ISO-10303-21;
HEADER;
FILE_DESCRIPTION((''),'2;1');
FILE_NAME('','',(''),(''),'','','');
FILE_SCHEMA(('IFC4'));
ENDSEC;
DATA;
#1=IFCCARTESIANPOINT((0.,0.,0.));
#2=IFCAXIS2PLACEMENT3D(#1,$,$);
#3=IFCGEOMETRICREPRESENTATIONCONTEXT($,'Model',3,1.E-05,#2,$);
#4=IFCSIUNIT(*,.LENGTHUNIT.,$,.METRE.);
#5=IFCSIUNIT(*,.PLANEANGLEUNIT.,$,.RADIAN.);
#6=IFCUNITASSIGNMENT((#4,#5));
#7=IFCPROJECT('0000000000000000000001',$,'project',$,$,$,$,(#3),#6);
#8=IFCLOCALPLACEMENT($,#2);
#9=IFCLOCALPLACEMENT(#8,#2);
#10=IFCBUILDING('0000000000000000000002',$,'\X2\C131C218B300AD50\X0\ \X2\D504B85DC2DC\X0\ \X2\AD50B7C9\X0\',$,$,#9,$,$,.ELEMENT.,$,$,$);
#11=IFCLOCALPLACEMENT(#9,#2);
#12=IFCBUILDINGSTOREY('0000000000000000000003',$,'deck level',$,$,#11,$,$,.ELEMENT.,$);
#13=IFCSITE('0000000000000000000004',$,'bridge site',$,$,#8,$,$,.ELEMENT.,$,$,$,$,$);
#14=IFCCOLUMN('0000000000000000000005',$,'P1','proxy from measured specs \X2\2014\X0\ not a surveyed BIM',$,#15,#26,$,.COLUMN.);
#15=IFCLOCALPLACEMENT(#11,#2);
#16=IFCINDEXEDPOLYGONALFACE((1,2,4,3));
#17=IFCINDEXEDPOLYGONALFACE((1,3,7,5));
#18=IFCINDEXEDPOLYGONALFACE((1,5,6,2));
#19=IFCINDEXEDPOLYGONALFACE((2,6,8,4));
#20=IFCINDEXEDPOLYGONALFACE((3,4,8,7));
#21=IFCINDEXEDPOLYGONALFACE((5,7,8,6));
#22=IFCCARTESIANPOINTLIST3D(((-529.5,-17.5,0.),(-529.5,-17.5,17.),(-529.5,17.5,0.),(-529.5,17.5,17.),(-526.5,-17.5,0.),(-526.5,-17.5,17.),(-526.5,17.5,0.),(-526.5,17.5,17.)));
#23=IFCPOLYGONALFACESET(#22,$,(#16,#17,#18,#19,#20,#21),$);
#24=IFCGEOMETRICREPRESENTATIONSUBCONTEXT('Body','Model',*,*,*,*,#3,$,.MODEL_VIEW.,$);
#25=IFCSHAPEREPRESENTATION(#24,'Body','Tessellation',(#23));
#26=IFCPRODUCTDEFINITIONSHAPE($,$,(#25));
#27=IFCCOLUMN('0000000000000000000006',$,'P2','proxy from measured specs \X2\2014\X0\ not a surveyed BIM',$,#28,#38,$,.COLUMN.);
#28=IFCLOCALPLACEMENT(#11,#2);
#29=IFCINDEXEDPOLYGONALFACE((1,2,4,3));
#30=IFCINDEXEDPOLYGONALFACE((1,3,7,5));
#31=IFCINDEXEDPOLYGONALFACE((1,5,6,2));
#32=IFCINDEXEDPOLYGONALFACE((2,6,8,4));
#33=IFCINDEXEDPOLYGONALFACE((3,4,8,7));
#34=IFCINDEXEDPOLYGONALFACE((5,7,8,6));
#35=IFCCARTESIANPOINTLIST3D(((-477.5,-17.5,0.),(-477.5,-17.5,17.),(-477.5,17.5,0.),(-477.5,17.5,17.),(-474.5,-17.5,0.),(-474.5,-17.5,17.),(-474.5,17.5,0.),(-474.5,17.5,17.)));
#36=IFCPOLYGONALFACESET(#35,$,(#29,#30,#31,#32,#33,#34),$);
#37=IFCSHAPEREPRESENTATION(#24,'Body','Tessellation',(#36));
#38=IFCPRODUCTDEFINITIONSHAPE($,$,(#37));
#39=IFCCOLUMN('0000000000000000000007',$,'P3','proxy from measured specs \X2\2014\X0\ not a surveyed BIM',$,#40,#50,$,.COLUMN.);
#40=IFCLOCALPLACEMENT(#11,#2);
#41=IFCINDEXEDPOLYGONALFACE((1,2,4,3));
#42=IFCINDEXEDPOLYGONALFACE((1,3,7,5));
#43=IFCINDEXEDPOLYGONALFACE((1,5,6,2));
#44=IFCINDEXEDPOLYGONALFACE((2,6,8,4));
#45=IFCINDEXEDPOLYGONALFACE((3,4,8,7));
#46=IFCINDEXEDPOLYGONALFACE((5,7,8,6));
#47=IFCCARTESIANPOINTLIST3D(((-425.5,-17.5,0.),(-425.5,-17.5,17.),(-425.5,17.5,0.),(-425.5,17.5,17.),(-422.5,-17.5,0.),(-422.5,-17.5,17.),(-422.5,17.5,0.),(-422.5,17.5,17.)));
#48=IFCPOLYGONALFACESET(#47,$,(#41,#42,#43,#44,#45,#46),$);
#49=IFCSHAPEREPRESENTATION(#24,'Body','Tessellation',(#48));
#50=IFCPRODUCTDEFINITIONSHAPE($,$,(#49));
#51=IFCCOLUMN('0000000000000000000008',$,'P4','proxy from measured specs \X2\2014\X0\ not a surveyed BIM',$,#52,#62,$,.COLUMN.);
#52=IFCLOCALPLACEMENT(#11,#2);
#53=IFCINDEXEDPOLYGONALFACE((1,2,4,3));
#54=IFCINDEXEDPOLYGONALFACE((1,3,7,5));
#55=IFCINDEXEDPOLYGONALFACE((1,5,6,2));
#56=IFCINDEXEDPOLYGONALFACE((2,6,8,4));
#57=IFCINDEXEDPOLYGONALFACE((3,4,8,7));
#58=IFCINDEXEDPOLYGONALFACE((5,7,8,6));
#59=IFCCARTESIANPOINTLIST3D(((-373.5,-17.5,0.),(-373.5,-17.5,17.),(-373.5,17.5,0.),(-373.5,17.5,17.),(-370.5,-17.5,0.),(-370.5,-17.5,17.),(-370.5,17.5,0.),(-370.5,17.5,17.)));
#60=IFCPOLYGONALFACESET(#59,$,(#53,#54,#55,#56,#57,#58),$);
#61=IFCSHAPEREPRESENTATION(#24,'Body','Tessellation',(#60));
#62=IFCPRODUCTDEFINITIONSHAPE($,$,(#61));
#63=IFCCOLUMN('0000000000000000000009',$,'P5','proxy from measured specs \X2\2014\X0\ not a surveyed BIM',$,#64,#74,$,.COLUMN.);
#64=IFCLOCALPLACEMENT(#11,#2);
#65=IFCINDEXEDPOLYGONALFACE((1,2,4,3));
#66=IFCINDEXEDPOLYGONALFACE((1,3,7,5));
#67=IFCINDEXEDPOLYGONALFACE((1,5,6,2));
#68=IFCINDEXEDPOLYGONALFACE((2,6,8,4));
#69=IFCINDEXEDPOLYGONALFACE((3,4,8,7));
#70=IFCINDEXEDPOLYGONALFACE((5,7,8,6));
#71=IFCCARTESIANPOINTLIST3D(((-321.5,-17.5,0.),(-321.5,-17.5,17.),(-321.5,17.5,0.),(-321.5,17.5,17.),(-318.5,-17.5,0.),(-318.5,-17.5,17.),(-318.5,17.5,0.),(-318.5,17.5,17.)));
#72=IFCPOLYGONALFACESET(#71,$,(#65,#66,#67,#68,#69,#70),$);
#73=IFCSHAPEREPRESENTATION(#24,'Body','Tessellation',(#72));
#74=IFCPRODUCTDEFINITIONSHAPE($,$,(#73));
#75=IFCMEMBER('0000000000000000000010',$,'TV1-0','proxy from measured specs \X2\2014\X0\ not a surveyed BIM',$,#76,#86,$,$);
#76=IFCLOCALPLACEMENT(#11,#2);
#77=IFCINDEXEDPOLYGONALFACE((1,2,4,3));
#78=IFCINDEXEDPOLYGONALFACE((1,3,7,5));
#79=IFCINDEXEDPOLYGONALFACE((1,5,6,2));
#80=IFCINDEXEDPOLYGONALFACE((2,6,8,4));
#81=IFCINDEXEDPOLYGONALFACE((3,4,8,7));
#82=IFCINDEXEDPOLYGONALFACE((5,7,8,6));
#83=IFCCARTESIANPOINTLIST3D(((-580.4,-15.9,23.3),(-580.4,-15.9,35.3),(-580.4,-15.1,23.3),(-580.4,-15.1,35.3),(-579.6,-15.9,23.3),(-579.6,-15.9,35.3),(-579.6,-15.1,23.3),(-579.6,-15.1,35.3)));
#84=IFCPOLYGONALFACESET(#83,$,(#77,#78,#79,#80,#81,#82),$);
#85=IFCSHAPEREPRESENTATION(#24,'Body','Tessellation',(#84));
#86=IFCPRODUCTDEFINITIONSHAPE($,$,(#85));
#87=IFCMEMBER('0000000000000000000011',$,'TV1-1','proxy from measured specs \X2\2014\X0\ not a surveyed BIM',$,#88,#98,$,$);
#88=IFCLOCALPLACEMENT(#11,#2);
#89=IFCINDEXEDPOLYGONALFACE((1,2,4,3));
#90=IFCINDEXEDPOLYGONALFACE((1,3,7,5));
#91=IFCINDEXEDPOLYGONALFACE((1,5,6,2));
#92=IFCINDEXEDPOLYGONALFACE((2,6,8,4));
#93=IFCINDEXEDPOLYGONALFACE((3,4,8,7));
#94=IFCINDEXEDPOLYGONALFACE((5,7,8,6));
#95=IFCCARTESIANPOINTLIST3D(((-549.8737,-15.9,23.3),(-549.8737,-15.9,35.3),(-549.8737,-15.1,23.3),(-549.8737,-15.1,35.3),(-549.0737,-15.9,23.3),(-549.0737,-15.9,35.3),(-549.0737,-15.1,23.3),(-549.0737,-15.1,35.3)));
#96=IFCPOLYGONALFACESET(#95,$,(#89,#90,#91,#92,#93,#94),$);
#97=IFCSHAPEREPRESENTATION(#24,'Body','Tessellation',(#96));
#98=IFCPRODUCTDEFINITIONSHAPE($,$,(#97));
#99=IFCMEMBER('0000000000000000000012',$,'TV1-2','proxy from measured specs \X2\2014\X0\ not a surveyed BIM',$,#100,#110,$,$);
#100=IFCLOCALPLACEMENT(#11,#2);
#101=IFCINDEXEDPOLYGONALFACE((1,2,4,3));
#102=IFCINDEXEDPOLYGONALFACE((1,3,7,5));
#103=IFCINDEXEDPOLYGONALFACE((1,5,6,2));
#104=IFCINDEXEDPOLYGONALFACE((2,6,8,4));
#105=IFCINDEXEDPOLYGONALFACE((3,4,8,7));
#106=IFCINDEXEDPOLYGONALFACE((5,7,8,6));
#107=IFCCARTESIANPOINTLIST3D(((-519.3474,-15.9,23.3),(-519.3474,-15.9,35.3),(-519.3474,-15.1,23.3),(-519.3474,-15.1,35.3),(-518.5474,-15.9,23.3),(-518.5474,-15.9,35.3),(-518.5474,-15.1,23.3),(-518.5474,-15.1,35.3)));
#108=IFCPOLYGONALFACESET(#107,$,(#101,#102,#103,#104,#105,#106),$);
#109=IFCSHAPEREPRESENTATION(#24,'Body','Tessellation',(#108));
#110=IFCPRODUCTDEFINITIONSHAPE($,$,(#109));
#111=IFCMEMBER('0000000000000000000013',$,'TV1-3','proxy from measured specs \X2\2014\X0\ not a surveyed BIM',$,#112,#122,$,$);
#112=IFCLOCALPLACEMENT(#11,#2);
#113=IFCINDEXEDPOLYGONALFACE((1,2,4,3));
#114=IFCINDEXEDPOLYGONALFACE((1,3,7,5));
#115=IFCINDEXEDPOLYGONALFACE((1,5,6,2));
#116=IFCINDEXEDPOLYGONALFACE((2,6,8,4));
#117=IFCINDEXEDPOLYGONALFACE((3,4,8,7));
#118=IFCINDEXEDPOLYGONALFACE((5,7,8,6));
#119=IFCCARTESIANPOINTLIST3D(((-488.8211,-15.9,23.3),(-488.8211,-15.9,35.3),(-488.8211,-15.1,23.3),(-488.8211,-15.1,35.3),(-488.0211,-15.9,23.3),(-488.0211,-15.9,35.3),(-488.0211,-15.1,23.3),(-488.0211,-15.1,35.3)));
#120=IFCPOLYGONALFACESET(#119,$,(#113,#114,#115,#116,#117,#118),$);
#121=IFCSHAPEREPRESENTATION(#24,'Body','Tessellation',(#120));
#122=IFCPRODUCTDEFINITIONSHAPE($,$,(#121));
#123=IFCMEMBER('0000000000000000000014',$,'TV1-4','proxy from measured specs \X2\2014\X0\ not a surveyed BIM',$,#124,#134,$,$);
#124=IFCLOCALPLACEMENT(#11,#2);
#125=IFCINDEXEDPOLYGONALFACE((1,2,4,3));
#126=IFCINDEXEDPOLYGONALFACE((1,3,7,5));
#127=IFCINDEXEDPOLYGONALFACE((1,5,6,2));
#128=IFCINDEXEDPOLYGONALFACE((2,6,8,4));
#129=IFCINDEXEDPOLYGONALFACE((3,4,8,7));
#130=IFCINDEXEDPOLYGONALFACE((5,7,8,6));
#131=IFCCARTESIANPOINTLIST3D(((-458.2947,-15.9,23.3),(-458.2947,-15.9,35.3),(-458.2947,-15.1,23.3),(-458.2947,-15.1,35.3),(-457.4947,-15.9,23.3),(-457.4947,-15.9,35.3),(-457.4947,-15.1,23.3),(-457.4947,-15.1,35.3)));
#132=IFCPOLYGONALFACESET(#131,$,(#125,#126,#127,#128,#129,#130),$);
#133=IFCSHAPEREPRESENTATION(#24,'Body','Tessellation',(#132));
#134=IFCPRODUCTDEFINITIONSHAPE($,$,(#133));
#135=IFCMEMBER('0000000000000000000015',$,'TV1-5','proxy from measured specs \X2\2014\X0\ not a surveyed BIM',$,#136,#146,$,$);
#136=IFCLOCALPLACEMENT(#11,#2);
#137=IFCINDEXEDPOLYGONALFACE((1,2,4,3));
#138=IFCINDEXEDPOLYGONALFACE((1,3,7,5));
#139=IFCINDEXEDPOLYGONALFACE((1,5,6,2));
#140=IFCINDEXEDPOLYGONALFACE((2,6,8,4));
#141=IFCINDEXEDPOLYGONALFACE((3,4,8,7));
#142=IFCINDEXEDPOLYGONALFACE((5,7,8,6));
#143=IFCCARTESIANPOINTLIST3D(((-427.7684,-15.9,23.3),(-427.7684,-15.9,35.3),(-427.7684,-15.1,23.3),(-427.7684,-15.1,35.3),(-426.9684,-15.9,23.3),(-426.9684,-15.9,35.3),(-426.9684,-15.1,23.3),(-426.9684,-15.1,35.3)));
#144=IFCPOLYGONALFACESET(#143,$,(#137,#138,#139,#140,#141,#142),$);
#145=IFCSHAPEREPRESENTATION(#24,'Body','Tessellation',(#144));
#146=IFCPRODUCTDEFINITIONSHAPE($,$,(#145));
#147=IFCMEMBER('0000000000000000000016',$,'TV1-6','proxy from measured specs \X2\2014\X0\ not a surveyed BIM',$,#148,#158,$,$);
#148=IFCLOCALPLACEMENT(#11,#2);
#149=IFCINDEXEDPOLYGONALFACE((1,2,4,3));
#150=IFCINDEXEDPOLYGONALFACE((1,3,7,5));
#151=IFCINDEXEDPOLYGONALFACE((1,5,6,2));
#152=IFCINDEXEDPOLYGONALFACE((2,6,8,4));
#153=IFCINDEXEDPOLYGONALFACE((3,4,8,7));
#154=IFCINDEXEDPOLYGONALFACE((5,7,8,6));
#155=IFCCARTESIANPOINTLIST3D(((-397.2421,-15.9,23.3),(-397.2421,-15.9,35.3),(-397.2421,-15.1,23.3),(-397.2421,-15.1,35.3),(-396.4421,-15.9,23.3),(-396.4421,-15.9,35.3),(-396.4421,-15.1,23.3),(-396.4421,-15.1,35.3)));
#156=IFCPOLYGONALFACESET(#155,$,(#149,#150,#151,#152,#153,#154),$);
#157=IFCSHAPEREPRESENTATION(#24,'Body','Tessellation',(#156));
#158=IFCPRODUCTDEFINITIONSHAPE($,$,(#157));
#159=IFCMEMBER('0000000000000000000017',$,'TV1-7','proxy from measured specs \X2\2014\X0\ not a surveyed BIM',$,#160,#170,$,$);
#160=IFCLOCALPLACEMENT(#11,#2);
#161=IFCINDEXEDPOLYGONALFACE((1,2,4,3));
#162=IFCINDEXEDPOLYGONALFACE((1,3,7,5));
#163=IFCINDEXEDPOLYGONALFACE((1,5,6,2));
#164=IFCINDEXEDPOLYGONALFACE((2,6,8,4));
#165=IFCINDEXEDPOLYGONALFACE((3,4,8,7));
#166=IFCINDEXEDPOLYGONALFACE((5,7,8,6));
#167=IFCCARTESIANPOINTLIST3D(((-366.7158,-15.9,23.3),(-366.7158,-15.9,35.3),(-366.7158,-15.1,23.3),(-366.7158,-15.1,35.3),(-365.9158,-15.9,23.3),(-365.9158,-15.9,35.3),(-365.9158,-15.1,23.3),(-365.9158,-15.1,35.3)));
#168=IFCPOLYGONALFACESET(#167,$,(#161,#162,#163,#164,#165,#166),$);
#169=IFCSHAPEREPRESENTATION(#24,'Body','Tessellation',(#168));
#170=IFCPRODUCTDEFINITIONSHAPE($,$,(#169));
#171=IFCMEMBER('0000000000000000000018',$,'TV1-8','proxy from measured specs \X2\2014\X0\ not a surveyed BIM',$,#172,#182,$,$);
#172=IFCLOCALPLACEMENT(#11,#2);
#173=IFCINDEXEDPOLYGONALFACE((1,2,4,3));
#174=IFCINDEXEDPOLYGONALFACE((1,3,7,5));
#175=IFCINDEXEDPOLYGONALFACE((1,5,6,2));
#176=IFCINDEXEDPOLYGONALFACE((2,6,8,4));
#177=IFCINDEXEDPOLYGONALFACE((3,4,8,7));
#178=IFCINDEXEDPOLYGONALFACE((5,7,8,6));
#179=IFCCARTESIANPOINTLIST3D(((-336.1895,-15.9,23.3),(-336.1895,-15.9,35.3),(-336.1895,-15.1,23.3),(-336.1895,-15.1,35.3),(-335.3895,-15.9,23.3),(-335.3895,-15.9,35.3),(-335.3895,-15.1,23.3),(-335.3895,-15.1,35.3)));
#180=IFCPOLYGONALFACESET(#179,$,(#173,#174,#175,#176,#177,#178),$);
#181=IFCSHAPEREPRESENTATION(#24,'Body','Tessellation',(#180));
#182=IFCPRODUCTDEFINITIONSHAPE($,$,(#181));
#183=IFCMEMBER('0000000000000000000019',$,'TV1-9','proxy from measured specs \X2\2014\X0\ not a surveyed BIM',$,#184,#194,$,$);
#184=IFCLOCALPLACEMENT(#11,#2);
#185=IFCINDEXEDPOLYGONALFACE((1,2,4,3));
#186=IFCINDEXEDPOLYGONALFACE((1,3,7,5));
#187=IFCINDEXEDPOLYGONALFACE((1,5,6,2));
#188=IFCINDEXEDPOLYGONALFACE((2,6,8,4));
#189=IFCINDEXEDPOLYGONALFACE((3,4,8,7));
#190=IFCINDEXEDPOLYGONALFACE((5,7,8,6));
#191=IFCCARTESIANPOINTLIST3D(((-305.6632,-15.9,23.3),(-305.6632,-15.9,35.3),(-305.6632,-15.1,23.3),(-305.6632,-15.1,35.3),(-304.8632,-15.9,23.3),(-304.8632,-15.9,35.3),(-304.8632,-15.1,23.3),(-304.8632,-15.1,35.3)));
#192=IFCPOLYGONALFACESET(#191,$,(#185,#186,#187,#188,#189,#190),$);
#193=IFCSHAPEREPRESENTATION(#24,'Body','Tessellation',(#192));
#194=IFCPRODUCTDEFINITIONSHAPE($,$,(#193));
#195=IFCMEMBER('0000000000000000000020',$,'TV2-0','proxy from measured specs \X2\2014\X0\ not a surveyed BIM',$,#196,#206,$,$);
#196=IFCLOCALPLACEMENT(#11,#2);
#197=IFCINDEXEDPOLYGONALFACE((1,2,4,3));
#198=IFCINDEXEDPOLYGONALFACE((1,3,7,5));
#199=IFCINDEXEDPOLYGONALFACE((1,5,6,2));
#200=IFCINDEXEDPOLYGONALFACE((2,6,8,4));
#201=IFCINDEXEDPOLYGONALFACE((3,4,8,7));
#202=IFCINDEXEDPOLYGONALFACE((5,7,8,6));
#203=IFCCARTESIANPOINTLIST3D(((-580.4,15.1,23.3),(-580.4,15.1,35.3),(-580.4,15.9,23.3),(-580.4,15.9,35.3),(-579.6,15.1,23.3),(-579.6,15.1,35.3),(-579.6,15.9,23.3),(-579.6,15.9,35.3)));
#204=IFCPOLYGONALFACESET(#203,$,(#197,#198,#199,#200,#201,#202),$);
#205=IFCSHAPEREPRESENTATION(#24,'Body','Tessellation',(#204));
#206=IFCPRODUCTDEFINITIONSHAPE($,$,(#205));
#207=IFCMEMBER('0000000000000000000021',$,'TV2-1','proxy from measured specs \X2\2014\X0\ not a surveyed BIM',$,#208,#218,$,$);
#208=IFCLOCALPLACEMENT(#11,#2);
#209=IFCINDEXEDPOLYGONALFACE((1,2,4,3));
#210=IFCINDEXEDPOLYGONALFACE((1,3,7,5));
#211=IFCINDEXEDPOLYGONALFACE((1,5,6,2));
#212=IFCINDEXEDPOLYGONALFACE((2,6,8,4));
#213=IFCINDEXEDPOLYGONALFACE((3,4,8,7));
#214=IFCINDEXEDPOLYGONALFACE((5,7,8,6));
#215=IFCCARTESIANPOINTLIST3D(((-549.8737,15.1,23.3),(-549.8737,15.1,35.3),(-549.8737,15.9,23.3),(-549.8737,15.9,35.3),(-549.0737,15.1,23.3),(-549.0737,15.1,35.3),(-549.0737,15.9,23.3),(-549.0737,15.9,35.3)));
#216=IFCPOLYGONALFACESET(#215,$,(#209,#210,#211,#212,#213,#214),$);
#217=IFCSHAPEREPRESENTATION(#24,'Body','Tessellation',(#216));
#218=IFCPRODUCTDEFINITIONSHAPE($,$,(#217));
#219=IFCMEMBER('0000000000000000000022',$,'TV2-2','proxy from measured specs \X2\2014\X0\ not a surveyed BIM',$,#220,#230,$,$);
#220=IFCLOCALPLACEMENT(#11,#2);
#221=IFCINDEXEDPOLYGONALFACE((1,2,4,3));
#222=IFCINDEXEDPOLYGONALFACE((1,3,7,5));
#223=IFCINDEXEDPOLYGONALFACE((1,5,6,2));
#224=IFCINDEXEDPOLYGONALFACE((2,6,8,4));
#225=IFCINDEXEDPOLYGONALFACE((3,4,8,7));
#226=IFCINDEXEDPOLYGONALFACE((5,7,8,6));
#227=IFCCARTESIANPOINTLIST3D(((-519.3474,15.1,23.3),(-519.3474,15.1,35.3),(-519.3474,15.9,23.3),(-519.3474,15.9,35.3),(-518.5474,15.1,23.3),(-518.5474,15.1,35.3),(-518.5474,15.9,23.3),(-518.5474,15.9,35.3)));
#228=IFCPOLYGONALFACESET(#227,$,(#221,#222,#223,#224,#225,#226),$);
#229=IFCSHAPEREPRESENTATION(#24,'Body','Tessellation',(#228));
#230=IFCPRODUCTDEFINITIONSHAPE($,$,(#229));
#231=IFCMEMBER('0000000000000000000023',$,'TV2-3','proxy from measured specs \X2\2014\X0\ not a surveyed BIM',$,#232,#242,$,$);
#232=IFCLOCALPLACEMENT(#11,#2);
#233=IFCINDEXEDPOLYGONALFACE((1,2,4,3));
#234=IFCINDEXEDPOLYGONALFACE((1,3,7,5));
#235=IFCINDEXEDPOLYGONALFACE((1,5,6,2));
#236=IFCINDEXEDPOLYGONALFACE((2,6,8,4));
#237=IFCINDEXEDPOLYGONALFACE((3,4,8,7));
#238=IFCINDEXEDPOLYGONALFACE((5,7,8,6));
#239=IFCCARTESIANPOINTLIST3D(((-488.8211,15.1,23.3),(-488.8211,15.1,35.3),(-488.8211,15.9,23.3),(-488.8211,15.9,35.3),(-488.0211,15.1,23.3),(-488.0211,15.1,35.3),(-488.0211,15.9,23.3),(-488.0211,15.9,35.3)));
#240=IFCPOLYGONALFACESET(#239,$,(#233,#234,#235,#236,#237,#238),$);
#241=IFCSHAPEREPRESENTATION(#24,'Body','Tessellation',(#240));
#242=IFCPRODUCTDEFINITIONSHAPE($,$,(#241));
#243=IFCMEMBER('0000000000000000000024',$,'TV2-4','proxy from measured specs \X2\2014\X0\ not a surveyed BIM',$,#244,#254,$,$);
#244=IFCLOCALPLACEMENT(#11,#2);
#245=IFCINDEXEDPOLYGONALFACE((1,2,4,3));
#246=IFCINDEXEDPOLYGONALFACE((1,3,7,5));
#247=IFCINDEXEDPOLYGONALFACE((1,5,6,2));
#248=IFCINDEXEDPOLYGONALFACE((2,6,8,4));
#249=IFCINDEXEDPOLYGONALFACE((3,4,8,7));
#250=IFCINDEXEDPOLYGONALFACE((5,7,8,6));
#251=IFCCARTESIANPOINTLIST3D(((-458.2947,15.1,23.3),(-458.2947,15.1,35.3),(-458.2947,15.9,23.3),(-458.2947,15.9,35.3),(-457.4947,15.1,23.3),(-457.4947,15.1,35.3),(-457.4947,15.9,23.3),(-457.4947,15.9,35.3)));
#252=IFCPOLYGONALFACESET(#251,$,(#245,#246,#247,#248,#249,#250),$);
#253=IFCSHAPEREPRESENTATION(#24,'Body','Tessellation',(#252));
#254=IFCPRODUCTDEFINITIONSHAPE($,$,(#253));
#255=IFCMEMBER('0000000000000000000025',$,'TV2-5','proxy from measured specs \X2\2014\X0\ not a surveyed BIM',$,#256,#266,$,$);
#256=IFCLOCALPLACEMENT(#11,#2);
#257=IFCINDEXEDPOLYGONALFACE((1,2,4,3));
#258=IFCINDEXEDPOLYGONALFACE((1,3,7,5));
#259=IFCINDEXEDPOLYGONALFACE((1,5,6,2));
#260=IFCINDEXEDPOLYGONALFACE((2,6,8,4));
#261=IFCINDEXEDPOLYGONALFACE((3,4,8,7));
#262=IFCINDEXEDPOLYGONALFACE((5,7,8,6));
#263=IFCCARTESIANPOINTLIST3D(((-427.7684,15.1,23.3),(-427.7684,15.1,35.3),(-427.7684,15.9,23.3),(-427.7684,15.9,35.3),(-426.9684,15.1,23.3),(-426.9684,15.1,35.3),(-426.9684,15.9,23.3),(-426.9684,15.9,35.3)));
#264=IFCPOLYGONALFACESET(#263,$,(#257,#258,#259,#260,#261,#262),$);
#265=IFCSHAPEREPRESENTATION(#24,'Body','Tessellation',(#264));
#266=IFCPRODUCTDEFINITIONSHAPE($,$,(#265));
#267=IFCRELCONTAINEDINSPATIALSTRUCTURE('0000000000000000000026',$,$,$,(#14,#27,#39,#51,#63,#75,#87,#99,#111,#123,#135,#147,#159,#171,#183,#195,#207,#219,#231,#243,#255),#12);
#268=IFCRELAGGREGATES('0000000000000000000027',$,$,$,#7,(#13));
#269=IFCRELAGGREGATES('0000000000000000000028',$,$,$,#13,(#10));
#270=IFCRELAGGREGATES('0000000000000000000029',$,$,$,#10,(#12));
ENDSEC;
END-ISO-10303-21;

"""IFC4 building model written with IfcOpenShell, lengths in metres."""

from ifc_helpers import new_model, si_unit, frame, origin, origin_2d, place, context, subcontext, project, spatial, rectangle, extrude, element, save


model = new_model("IFC4")

# Units and contexts
model_context = context("Model", 3, precision=1e-05, world=origin())
body_context = subcontext(model_context, "Body", "Model", "MODEL_VIEW")
ifc_project = project(units=[si_unit("LENGTHUNIT", "METRE"), si_unit("PLANEANGLEUNIT", "RADIAN")], contexts=[model_context])

# Site, building, storey
site_placement = place(None, origin())
site = spatial("IfcSite", under=ifc_project, at=site_placement, Name="bridge site", CompositionType="ELEMENT")
building_placement = place(site_placement, origin())
building = spatial("IfcBuilding", under=site, at=building_placement, Name="성수대교 프록시 교량", CompositionType="ELEMENT")
storey_placement = place(building_placement, origin())
storey = spatial("IfcBuildingStorey", under=building, at=storey_placement, Name="deck level", CompositionType="ELEMENT")

# Columns
for number, where, name in (
    (1, (-528.0, 0.0, 0.0), "P1"),
    (2, (-476.0, 0.0, 0.0), "P2"),
    (3, (-424.0, 0.0, 0.0), "P3"),
    (4, (-372.0, 0.0, 0.0), "P4"),
    (5, (-320.0, 0.0, 0.0), "P5"),
):
    element("IfcColumn", number, at=place(storey_placement, frame(where)), inside=storey, Name=name, Description="proxy from measured specs — not a surveyed BIM", PredefinedType="COLUMN", context=body_context, shape_type="SweptSolid", body=[
        extrude(rectangle(XDim=3.0, YDim=35.0, at=origin_2d()), origin(), (0.0, 0.0, 1.0), 17.0),
    ])

# Members
for number, where, name in (
    (6, (-580.0, -15.5, 23.3), "TV1-0"),
    (7, (-549.4737, -15.5, 23.3), "TV1-1"),
    (8, (-518.9474, -15.5, 23.3), "TV1-2"),
    (9, (-488.4211, -15.5, 23.3), "TV1-3"),
    (10, (-457.8947, -15.5, 23.3), "TV1-4"),
    (11, (-427.3684, -15.5, 23.3), "TV1-5"),
    (12, (-396.8421, -15.5, 23.3), "TV1-6"),
    (13, (-366.3158, -15.5, 23.3), "TV1-7"),
    (14, (-335.7895, -15.5, 23.3), "TV1-8"),
    (15, (-305.2632, -15.5, 23.3), "TV1-9"),
    (16, (-580.0, 15.5, 23.3), "TV2-0"),
    (17, (-549.4737, 15.5, 23.3), "TV2-1"),
    (18, (-518.9474, 15.5, 23.3), "TV2-2"),
    (19, (-488.4211, 15.5, 23.3), "TV2-3"),
    (20, (-457.8947, 15.5, 23.3), "TV2-4"),
    (21, (-427.3684, 15.5, 23.3), "TV2-5"),
):
    element("IfcMember", number, at=place(storey_placement, frame(where)), inside=storey, Name=name, Description="proxy from measured specs — not a surveyed BIM", context=body_context, shape_type="SweptSolid", body=[
        extrude(rectangle(XDim=0.8, YDim=0.8, at=origin_2d()), origin(), (0.0, 0.0, 1.0), 12.0),
    ])

save(model, "model.ifc")
